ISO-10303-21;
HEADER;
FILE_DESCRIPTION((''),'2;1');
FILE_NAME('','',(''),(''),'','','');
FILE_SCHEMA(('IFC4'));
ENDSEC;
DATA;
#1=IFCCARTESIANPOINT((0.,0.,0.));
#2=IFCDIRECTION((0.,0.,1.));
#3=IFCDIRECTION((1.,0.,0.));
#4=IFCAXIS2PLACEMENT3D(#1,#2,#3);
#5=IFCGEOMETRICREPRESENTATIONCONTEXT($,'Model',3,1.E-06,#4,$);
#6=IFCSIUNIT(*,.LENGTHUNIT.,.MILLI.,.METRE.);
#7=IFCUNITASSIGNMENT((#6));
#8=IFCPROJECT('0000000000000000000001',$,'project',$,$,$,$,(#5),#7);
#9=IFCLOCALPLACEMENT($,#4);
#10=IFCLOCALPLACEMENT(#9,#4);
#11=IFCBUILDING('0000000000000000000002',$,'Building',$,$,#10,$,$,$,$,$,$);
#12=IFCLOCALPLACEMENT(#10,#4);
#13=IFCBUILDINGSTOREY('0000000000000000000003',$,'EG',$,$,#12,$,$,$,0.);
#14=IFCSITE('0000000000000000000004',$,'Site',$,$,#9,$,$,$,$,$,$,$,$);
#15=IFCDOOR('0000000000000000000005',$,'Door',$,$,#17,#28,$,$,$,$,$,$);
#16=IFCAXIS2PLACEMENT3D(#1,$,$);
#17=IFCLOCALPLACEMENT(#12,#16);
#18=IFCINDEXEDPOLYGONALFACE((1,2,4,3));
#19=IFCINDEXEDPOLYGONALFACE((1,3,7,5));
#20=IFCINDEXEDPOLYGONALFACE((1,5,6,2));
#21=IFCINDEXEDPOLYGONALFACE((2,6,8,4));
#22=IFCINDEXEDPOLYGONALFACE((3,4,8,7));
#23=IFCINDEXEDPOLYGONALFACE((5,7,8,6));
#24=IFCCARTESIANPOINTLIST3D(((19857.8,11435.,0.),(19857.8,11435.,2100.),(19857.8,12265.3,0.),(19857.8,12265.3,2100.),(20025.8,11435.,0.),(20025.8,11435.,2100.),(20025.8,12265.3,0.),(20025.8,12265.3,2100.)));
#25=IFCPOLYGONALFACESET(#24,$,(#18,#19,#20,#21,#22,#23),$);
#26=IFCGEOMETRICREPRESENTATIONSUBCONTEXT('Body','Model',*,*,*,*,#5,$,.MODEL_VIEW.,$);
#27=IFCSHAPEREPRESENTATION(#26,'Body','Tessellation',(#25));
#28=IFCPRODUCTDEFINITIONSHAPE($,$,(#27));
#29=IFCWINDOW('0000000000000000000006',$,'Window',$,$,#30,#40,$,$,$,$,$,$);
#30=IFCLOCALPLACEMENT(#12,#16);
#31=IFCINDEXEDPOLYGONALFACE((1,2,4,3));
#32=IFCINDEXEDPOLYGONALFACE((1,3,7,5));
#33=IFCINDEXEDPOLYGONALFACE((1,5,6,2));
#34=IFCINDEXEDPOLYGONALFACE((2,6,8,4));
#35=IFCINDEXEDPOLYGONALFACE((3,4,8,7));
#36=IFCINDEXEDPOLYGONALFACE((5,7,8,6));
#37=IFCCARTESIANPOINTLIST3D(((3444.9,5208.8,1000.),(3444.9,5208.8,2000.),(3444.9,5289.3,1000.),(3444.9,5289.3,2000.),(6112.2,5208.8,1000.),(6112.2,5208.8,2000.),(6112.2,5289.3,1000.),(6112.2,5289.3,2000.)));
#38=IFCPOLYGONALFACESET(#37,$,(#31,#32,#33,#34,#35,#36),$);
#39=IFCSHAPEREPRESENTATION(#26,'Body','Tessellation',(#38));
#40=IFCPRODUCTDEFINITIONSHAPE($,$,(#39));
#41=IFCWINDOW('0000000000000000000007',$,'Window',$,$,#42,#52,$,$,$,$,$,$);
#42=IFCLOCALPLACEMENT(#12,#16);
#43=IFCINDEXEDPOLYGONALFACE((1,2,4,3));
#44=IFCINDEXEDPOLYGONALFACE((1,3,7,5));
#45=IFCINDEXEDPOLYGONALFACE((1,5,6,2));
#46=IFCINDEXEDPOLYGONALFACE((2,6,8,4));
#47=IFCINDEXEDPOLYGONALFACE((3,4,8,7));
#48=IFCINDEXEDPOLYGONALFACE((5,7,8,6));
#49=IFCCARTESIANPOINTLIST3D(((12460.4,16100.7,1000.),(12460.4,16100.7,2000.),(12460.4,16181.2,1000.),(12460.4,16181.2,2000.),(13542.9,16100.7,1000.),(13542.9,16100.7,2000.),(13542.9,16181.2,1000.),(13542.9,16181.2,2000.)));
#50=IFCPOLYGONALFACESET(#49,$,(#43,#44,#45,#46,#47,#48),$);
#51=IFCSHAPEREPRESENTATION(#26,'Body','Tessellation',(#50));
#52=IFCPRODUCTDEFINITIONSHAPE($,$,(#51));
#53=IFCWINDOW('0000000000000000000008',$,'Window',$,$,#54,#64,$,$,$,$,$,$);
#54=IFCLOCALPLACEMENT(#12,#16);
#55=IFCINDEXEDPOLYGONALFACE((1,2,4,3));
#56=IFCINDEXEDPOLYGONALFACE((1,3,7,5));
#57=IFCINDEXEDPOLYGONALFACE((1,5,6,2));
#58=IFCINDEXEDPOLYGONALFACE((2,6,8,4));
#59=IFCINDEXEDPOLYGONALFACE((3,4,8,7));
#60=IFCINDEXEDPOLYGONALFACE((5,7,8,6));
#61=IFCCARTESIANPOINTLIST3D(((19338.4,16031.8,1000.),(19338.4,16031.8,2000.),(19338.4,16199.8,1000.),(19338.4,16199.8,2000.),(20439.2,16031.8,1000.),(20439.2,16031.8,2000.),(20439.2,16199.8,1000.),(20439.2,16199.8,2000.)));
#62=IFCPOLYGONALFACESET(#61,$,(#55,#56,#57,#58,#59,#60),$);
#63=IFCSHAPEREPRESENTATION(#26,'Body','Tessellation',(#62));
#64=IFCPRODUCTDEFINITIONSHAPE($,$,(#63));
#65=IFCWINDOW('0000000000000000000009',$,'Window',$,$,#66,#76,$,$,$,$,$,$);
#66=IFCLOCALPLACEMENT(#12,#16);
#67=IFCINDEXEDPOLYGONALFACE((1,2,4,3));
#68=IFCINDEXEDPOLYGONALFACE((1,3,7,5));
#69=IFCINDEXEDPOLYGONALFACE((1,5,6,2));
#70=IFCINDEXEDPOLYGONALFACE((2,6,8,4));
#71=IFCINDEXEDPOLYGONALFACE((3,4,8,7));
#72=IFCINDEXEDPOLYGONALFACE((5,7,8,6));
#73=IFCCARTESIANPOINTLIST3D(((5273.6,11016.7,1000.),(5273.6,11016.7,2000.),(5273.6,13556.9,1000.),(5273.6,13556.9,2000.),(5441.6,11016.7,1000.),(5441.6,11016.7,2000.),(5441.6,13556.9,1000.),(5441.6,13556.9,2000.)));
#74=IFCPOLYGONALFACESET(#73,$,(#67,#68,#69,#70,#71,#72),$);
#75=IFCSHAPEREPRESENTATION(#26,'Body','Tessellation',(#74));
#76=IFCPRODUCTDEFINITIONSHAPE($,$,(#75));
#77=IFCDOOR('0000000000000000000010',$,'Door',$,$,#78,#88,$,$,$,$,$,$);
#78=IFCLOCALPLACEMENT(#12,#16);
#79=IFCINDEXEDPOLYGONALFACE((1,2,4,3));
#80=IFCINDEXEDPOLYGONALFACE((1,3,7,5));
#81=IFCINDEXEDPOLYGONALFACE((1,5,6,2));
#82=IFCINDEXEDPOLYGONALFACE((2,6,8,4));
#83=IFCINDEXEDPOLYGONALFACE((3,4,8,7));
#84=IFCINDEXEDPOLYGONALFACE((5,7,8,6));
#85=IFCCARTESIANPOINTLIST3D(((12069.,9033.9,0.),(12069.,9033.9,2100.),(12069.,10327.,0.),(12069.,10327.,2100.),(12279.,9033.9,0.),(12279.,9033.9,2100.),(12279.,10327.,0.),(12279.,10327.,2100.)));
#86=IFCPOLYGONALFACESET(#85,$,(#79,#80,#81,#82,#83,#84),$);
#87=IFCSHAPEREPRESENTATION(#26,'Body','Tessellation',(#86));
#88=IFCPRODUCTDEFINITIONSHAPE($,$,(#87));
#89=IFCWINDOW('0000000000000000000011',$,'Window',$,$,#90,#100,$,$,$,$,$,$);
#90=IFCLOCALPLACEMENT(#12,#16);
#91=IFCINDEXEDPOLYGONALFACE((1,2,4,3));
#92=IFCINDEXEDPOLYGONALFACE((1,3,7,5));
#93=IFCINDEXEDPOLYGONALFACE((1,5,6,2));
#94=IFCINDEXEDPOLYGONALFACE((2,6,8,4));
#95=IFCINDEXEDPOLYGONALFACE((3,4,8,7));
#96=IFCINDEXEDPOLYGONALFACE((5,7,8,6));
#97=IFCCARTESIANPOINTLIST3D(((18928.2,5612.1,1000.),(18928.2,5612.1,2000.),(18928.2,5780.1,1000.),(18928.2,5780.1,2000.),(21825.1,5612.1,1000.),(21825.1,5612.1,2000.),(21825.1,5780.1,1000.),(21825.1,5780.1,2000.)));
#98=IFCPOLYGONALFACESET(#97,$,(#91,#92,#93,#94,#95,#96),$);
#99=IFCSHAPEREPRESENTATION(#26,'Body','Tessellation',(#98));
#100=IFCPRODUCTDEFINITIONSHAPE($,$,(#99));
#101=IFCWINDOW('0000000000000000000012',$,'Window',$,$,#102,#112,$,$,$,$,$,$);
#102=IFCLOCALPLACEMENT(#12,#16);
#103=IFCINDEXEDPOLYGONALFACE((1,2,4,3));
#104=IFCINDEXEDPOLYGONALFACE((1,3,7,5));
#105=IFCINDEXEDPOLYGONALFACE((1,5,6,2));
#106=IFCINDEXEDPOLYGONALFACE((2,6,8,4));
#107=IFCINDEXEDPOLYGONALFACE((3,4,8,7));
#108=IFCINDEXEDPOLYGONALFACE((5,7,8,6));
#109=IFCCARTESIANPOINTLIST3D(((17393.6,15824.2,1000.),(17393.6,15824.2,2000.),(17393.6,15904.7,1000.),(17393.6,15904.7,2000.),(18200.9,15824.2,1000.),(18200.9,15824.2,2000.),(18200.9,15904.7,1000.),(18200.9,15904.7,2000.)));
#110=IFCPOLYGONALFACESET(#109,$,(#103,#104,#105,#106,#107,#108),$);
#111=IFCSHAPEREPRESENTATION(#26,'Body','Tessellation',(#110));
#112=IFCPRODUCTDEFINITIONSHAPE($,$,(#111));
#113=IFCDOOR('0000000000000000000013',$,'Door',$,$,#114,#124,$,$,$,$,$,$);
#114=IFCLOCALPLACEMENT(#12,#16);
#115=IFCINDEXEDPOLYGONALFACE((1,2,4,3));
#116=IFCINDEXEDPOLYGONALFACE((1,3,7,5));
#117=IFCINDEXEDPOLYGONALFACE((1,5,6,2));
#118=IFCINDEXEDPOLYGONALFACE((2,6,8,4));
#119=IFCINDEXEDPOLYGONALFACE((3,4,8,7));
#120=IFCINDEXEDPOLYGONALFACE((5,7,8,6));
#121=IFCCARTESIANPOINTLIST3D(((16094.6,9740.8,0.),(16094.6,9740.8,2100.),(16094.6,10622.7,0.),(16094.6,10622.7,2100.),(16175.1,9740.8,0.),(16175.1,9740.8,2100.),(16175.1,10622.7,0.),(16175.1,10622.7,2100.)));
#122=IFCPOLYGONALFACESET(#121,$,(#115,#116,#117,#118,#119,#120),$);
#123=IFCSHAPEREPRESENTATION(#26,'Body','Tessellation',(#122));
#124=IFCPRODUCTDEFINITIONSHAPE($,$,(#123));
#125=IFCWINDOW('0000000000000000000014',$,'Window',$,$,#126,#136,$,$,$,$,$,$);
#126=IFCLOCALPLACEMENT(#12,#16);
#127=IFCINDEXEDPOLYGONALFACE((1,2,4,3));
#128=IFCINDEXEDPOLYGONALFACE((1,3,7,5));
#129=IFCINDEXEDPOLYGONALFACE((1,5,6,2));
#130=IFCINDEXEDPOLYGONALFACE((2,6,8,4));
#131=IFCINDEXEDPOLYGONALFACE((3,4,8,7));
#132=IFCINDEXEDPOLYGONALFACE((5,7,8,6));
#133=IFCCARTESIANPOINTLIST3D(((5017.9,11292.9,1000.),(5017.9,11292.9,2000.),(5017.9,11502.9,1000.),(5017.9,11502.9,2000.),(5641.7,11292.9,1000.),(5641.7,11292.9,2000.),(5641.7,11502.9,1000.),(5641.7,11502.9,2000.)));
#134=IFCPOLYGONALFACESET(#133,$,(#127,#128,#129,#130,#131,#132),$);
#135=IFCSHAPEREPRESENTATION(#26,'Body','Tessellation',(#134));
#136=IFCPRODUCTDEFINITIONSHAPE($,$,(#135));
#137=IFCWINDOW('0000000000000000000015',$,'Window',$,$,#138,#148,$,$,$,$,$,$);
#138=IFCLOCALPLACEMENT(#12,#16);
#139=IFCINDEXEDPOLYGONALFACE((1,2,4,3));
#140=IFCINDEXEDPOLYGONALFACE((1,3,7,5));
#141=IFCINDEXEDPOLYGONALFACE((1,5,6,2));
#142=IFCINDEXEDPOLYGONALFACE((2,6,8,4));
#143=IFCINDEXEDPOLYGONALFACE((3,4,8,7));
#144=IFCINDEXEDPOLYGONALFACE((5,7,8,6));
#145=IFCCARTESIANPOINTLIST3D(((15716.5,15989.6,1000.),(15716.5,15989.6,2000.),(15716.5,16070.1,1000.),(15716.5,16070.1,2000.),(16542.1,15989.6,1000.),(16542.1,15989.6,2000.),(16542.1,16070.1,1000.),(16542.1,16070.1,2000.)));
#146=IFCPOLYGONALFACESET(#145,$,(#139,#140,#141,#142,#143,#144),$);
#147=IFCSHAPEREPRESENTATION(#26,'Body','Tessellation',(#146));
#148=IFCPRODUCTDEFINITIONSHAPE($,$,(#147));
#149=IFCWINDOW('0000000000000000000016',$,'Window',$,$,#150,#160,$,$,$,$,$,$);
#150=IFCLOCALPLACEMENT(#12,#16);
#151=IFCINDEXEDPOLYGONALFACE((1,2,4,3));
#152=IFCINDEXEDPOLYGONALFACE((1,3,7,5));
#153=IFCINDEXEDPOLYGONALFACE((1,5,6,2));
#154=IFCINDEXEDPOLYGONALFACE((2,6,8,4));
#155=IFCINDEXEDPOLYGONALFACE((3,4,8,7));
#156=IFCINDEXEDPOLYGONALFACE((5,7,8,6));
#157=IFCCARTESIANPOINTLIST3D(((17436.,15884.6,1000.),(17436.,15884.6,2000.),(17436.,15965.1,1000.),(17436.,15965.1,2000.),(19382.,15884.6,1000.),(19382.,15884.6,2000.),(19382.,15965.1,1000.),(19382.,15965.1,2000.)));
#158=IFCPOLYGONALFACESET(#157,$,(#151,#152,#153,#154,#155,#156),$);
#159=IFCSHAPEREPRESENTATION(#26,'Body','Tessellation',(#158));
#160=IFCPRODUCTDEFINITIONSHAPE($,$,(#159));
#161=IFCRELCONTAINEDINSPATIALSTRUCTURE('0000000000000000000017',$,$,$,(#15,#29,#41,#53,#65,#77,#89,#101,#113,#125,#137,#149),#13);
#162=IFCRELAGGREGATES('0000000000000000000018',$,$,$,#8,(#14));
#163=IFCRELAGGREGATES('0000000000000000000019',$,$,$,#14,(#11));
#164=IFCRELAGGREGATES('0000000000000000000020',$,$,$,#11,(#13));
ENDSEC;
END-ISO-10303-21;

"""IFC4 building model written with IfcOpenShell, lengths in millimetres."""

from ifc_helpers import new_model, si_unit, frame, origin_with_axes, place, context, subcontext, project, spatial, rectangle, extrude, element, save


model = new_model("IFC4")

# Units and contexts
model_context = context("Model", 3, precision=1e-06, world=origin_with_axes())
body_context = subcontext(model_context, "Body", "Model", "MODEL_VIEW")
ifc_project = project(units=[si_unit("LENGTHUNIT", "METRE", prefix="MILLI")], contexts=[model_context])

# Site, building, storey
site_placement = place(None, origin_with_axes())
site = spatial("IfcSite", under=ifc_project, at=site_placement, Name="Site")
building_placement = place(site_placement, origin_with_axes())
building = spatial("IfcBuilding", under=site, at=building_placement, Name="Building")
storey_placement = place(building_placement, origin_with_axes())
storey = spatial("IfcBuildingStorey", under=building, at=storey_placement, Name="EG", Elevation=0.0)

# Door
door_1_placement = place(storey_placement, origin_with_axes())
element("IfcDoor", 1, at=door_1_placement, inside=storey, Name="Door", context=body_context, shape_type="SweptSolid", body=[
    extrude(rectangle(XDim=830.3, YDim=168.0), frame((19941.8, 11850.2, 0.0), z_axis=(0.0, 0.0, 1.0), x_axis=(0.0, 1.0, 0.0)), (0.0, 0.0, 1.0), 2100.0),
])

# Windows
window_1_placement = place(storey_placement, origin_with_axes())
element("IfcWindow", 2, at=window_1_placement, inside=storey, Name="Window", context=body_context, shape_type="SweptSolid", body=[
    extrude(rectangle(XDim=2667.3, YDim=80.5), frame((4778.6, 5249.0, 1000.0), z_axis=(0.0, 0.0, 1.0), x_axis=(1.0, 0.0, 0.0)), (0.0, 0.0, 1.0), 1000.0),
])
window_2_placement = place(storey_placement, origin_with_axes())
element("IfcWindow", 3, at=window_2_placement, inside=storey, Name="Window", context=body_context, shape_type="SweptSolid", body=[
    extrude(rectangle(XDim=1082.5, YDim=80.5), frame((13001.7, 16141.0, 1000.0), z_axis=(0.0, 0.0, 1.0), x_axis=(1.0, 0.0, 0.0)), (0.0, 0.0, 1.0), 1000.0),
])
window_3_placement = place(storey_placement, origin_with_axes())
element("IfcWindow", 4, at=window_3_placement, inside=storey, Name="Window", context=body_context, shape_type="SweptSolid", body=[
    extrude(rectangle(XDim=1100.8, YDim=168.0), frame((19888.8, 16115.8, 1000.0), z_axis=(0.0, 0.0, 1.0), x_axis=(1.0, 0.0, 0.0)), (0.0, 0.0, 1.0), 1000.0),
])
window_4_placement = place(storey_placement, origin_with_axes())
element("IfcWindow", 5, at=window_4_placement, inside=storey, Name="Window", context=body_context, shape_type="SweptSolid", body=[
    extrude(rectangle(XDim=2540.3, YDim=168.0), frame((5357.6, 12286.8, 1000.0), z_axis=(0.0, 0.0, 1.0), x_axis=(0.0, 1.0, 0.0)), (0.0, 0.0, 1.0), 1000.0),
])

# Door
door_2_placement = place(storey_placement, origin_with_axes())
element("IfcDoor", 6, at=door_2_placement, inside=storey, Name="Door", context=body_context, shape_type="SweptSolid", body=[
    extrude(rectangle(XDim=1293.1, YDim=210.0), frame((12174.0, 9680.5, 0.0), z_axis=(0.0, 0.0, 1.0), x_axis=(0.0, 1.0, 0.0)), (0.0, 0.0, 1.0), 2100.0),
])

# Windows
window_5_placement = place(storey_placement, origin_with_axes())
element("IfcWindow", 7, at=window_5_placement, inside=storey, Name="Window", context=body_context, shape_type="SweptSolid", body=[
    extrude(rectangle(XDim=2896.9, YDim=168.0), frame((20376.7, 5696.1, 1000.0), z_axis=(0.0, 0.0, 1.0), x_axis=(1.0, 0.0, 0.0)), (0.0, 0.0, 1.0), 1000.0),
])
window_6_placement = place(storey_placement, origin_with_axes())
element("IfcWindow", 8, at=window_6_placement, inside=storey, Name="Window", context=body_context, shape_type="SweptSolid", body=[
    extrude(rectangle(XDim=807.3, YDim=80.5), frame((17797.2, 15864.5, 1000.0), z_axis=(0.0, 0.0, 1.0), x_axis=(1.0, 0.0, 0.0)), (0.0, 0.0, 1.0), 1000.0),
])

# Door
door_3_placement = place(storey_placement, origin_with_axes())
element("IfcDoor", 9, at=door_3_placement, inside=storey, Name="Door", context=body_context, shape_type="SweptSolid", body=[
    extrude(rectangle(XDim=881.9, YDim=80.5), frame((16134.9, 10181.8, 0.0), z_axis=(0.0, 0.0, 1.0), x_axis=(0.0, 1.0, 0.0)), (0.0, 0.0, 1.0), 2100.0),
])

# Windows
window_7_placement = place(storey_placement, origin_with_axes())
element("IfcWindow", 10, at=window_7_placement, inside=storey, Name="Window", context=body_context, shape_type="SweptSolid", body=[
    extrude(rectangle(XDim=623.8, YDim=210.0), frame((5329.8, 11397.9, 1000.0), z_axis=(0.0, 0.0, 1.0), x_axis=(1.0, 0.0, 0.0)), (0.0, 0.0, 1.0), 1000.0),
])
window_8_placement = place(storey_placement, origin_with_axes())
element("IfcWindow", 11, at=window_8_placement, inside=storey, Name="Window", context=body_context, shape_type="SweptSolid", body=[
    extrude(rectangle(XDim=825.6, YDim=80.5), frame((16129.3, 16029.9, 1000.0), z_axis=(0.0, 0.0, 1.0), x_axis=(1.0, 0.0, 0.0)), (0.0, 0.0, 1.0), 1000.0),
])
window_9_placement = place(storey_placement, origin_with_axes())
element("IfcWindow", 12, at=window_9_placement, inside=storey, Name="Window", context=body_context, shape_type="SweptSolid", body=[
    extrude(rectangle(XDim=1946.0, YDim=80.5), frame((18409.0, 15924.8, 1000.0), z_axis=(0.0, 0.0, 1.0), x_axis=(1.0, 0.0, 0.0)), (0.0, 0.0, 1.0), 1000.0),
])

save(model, "model.ifc")
